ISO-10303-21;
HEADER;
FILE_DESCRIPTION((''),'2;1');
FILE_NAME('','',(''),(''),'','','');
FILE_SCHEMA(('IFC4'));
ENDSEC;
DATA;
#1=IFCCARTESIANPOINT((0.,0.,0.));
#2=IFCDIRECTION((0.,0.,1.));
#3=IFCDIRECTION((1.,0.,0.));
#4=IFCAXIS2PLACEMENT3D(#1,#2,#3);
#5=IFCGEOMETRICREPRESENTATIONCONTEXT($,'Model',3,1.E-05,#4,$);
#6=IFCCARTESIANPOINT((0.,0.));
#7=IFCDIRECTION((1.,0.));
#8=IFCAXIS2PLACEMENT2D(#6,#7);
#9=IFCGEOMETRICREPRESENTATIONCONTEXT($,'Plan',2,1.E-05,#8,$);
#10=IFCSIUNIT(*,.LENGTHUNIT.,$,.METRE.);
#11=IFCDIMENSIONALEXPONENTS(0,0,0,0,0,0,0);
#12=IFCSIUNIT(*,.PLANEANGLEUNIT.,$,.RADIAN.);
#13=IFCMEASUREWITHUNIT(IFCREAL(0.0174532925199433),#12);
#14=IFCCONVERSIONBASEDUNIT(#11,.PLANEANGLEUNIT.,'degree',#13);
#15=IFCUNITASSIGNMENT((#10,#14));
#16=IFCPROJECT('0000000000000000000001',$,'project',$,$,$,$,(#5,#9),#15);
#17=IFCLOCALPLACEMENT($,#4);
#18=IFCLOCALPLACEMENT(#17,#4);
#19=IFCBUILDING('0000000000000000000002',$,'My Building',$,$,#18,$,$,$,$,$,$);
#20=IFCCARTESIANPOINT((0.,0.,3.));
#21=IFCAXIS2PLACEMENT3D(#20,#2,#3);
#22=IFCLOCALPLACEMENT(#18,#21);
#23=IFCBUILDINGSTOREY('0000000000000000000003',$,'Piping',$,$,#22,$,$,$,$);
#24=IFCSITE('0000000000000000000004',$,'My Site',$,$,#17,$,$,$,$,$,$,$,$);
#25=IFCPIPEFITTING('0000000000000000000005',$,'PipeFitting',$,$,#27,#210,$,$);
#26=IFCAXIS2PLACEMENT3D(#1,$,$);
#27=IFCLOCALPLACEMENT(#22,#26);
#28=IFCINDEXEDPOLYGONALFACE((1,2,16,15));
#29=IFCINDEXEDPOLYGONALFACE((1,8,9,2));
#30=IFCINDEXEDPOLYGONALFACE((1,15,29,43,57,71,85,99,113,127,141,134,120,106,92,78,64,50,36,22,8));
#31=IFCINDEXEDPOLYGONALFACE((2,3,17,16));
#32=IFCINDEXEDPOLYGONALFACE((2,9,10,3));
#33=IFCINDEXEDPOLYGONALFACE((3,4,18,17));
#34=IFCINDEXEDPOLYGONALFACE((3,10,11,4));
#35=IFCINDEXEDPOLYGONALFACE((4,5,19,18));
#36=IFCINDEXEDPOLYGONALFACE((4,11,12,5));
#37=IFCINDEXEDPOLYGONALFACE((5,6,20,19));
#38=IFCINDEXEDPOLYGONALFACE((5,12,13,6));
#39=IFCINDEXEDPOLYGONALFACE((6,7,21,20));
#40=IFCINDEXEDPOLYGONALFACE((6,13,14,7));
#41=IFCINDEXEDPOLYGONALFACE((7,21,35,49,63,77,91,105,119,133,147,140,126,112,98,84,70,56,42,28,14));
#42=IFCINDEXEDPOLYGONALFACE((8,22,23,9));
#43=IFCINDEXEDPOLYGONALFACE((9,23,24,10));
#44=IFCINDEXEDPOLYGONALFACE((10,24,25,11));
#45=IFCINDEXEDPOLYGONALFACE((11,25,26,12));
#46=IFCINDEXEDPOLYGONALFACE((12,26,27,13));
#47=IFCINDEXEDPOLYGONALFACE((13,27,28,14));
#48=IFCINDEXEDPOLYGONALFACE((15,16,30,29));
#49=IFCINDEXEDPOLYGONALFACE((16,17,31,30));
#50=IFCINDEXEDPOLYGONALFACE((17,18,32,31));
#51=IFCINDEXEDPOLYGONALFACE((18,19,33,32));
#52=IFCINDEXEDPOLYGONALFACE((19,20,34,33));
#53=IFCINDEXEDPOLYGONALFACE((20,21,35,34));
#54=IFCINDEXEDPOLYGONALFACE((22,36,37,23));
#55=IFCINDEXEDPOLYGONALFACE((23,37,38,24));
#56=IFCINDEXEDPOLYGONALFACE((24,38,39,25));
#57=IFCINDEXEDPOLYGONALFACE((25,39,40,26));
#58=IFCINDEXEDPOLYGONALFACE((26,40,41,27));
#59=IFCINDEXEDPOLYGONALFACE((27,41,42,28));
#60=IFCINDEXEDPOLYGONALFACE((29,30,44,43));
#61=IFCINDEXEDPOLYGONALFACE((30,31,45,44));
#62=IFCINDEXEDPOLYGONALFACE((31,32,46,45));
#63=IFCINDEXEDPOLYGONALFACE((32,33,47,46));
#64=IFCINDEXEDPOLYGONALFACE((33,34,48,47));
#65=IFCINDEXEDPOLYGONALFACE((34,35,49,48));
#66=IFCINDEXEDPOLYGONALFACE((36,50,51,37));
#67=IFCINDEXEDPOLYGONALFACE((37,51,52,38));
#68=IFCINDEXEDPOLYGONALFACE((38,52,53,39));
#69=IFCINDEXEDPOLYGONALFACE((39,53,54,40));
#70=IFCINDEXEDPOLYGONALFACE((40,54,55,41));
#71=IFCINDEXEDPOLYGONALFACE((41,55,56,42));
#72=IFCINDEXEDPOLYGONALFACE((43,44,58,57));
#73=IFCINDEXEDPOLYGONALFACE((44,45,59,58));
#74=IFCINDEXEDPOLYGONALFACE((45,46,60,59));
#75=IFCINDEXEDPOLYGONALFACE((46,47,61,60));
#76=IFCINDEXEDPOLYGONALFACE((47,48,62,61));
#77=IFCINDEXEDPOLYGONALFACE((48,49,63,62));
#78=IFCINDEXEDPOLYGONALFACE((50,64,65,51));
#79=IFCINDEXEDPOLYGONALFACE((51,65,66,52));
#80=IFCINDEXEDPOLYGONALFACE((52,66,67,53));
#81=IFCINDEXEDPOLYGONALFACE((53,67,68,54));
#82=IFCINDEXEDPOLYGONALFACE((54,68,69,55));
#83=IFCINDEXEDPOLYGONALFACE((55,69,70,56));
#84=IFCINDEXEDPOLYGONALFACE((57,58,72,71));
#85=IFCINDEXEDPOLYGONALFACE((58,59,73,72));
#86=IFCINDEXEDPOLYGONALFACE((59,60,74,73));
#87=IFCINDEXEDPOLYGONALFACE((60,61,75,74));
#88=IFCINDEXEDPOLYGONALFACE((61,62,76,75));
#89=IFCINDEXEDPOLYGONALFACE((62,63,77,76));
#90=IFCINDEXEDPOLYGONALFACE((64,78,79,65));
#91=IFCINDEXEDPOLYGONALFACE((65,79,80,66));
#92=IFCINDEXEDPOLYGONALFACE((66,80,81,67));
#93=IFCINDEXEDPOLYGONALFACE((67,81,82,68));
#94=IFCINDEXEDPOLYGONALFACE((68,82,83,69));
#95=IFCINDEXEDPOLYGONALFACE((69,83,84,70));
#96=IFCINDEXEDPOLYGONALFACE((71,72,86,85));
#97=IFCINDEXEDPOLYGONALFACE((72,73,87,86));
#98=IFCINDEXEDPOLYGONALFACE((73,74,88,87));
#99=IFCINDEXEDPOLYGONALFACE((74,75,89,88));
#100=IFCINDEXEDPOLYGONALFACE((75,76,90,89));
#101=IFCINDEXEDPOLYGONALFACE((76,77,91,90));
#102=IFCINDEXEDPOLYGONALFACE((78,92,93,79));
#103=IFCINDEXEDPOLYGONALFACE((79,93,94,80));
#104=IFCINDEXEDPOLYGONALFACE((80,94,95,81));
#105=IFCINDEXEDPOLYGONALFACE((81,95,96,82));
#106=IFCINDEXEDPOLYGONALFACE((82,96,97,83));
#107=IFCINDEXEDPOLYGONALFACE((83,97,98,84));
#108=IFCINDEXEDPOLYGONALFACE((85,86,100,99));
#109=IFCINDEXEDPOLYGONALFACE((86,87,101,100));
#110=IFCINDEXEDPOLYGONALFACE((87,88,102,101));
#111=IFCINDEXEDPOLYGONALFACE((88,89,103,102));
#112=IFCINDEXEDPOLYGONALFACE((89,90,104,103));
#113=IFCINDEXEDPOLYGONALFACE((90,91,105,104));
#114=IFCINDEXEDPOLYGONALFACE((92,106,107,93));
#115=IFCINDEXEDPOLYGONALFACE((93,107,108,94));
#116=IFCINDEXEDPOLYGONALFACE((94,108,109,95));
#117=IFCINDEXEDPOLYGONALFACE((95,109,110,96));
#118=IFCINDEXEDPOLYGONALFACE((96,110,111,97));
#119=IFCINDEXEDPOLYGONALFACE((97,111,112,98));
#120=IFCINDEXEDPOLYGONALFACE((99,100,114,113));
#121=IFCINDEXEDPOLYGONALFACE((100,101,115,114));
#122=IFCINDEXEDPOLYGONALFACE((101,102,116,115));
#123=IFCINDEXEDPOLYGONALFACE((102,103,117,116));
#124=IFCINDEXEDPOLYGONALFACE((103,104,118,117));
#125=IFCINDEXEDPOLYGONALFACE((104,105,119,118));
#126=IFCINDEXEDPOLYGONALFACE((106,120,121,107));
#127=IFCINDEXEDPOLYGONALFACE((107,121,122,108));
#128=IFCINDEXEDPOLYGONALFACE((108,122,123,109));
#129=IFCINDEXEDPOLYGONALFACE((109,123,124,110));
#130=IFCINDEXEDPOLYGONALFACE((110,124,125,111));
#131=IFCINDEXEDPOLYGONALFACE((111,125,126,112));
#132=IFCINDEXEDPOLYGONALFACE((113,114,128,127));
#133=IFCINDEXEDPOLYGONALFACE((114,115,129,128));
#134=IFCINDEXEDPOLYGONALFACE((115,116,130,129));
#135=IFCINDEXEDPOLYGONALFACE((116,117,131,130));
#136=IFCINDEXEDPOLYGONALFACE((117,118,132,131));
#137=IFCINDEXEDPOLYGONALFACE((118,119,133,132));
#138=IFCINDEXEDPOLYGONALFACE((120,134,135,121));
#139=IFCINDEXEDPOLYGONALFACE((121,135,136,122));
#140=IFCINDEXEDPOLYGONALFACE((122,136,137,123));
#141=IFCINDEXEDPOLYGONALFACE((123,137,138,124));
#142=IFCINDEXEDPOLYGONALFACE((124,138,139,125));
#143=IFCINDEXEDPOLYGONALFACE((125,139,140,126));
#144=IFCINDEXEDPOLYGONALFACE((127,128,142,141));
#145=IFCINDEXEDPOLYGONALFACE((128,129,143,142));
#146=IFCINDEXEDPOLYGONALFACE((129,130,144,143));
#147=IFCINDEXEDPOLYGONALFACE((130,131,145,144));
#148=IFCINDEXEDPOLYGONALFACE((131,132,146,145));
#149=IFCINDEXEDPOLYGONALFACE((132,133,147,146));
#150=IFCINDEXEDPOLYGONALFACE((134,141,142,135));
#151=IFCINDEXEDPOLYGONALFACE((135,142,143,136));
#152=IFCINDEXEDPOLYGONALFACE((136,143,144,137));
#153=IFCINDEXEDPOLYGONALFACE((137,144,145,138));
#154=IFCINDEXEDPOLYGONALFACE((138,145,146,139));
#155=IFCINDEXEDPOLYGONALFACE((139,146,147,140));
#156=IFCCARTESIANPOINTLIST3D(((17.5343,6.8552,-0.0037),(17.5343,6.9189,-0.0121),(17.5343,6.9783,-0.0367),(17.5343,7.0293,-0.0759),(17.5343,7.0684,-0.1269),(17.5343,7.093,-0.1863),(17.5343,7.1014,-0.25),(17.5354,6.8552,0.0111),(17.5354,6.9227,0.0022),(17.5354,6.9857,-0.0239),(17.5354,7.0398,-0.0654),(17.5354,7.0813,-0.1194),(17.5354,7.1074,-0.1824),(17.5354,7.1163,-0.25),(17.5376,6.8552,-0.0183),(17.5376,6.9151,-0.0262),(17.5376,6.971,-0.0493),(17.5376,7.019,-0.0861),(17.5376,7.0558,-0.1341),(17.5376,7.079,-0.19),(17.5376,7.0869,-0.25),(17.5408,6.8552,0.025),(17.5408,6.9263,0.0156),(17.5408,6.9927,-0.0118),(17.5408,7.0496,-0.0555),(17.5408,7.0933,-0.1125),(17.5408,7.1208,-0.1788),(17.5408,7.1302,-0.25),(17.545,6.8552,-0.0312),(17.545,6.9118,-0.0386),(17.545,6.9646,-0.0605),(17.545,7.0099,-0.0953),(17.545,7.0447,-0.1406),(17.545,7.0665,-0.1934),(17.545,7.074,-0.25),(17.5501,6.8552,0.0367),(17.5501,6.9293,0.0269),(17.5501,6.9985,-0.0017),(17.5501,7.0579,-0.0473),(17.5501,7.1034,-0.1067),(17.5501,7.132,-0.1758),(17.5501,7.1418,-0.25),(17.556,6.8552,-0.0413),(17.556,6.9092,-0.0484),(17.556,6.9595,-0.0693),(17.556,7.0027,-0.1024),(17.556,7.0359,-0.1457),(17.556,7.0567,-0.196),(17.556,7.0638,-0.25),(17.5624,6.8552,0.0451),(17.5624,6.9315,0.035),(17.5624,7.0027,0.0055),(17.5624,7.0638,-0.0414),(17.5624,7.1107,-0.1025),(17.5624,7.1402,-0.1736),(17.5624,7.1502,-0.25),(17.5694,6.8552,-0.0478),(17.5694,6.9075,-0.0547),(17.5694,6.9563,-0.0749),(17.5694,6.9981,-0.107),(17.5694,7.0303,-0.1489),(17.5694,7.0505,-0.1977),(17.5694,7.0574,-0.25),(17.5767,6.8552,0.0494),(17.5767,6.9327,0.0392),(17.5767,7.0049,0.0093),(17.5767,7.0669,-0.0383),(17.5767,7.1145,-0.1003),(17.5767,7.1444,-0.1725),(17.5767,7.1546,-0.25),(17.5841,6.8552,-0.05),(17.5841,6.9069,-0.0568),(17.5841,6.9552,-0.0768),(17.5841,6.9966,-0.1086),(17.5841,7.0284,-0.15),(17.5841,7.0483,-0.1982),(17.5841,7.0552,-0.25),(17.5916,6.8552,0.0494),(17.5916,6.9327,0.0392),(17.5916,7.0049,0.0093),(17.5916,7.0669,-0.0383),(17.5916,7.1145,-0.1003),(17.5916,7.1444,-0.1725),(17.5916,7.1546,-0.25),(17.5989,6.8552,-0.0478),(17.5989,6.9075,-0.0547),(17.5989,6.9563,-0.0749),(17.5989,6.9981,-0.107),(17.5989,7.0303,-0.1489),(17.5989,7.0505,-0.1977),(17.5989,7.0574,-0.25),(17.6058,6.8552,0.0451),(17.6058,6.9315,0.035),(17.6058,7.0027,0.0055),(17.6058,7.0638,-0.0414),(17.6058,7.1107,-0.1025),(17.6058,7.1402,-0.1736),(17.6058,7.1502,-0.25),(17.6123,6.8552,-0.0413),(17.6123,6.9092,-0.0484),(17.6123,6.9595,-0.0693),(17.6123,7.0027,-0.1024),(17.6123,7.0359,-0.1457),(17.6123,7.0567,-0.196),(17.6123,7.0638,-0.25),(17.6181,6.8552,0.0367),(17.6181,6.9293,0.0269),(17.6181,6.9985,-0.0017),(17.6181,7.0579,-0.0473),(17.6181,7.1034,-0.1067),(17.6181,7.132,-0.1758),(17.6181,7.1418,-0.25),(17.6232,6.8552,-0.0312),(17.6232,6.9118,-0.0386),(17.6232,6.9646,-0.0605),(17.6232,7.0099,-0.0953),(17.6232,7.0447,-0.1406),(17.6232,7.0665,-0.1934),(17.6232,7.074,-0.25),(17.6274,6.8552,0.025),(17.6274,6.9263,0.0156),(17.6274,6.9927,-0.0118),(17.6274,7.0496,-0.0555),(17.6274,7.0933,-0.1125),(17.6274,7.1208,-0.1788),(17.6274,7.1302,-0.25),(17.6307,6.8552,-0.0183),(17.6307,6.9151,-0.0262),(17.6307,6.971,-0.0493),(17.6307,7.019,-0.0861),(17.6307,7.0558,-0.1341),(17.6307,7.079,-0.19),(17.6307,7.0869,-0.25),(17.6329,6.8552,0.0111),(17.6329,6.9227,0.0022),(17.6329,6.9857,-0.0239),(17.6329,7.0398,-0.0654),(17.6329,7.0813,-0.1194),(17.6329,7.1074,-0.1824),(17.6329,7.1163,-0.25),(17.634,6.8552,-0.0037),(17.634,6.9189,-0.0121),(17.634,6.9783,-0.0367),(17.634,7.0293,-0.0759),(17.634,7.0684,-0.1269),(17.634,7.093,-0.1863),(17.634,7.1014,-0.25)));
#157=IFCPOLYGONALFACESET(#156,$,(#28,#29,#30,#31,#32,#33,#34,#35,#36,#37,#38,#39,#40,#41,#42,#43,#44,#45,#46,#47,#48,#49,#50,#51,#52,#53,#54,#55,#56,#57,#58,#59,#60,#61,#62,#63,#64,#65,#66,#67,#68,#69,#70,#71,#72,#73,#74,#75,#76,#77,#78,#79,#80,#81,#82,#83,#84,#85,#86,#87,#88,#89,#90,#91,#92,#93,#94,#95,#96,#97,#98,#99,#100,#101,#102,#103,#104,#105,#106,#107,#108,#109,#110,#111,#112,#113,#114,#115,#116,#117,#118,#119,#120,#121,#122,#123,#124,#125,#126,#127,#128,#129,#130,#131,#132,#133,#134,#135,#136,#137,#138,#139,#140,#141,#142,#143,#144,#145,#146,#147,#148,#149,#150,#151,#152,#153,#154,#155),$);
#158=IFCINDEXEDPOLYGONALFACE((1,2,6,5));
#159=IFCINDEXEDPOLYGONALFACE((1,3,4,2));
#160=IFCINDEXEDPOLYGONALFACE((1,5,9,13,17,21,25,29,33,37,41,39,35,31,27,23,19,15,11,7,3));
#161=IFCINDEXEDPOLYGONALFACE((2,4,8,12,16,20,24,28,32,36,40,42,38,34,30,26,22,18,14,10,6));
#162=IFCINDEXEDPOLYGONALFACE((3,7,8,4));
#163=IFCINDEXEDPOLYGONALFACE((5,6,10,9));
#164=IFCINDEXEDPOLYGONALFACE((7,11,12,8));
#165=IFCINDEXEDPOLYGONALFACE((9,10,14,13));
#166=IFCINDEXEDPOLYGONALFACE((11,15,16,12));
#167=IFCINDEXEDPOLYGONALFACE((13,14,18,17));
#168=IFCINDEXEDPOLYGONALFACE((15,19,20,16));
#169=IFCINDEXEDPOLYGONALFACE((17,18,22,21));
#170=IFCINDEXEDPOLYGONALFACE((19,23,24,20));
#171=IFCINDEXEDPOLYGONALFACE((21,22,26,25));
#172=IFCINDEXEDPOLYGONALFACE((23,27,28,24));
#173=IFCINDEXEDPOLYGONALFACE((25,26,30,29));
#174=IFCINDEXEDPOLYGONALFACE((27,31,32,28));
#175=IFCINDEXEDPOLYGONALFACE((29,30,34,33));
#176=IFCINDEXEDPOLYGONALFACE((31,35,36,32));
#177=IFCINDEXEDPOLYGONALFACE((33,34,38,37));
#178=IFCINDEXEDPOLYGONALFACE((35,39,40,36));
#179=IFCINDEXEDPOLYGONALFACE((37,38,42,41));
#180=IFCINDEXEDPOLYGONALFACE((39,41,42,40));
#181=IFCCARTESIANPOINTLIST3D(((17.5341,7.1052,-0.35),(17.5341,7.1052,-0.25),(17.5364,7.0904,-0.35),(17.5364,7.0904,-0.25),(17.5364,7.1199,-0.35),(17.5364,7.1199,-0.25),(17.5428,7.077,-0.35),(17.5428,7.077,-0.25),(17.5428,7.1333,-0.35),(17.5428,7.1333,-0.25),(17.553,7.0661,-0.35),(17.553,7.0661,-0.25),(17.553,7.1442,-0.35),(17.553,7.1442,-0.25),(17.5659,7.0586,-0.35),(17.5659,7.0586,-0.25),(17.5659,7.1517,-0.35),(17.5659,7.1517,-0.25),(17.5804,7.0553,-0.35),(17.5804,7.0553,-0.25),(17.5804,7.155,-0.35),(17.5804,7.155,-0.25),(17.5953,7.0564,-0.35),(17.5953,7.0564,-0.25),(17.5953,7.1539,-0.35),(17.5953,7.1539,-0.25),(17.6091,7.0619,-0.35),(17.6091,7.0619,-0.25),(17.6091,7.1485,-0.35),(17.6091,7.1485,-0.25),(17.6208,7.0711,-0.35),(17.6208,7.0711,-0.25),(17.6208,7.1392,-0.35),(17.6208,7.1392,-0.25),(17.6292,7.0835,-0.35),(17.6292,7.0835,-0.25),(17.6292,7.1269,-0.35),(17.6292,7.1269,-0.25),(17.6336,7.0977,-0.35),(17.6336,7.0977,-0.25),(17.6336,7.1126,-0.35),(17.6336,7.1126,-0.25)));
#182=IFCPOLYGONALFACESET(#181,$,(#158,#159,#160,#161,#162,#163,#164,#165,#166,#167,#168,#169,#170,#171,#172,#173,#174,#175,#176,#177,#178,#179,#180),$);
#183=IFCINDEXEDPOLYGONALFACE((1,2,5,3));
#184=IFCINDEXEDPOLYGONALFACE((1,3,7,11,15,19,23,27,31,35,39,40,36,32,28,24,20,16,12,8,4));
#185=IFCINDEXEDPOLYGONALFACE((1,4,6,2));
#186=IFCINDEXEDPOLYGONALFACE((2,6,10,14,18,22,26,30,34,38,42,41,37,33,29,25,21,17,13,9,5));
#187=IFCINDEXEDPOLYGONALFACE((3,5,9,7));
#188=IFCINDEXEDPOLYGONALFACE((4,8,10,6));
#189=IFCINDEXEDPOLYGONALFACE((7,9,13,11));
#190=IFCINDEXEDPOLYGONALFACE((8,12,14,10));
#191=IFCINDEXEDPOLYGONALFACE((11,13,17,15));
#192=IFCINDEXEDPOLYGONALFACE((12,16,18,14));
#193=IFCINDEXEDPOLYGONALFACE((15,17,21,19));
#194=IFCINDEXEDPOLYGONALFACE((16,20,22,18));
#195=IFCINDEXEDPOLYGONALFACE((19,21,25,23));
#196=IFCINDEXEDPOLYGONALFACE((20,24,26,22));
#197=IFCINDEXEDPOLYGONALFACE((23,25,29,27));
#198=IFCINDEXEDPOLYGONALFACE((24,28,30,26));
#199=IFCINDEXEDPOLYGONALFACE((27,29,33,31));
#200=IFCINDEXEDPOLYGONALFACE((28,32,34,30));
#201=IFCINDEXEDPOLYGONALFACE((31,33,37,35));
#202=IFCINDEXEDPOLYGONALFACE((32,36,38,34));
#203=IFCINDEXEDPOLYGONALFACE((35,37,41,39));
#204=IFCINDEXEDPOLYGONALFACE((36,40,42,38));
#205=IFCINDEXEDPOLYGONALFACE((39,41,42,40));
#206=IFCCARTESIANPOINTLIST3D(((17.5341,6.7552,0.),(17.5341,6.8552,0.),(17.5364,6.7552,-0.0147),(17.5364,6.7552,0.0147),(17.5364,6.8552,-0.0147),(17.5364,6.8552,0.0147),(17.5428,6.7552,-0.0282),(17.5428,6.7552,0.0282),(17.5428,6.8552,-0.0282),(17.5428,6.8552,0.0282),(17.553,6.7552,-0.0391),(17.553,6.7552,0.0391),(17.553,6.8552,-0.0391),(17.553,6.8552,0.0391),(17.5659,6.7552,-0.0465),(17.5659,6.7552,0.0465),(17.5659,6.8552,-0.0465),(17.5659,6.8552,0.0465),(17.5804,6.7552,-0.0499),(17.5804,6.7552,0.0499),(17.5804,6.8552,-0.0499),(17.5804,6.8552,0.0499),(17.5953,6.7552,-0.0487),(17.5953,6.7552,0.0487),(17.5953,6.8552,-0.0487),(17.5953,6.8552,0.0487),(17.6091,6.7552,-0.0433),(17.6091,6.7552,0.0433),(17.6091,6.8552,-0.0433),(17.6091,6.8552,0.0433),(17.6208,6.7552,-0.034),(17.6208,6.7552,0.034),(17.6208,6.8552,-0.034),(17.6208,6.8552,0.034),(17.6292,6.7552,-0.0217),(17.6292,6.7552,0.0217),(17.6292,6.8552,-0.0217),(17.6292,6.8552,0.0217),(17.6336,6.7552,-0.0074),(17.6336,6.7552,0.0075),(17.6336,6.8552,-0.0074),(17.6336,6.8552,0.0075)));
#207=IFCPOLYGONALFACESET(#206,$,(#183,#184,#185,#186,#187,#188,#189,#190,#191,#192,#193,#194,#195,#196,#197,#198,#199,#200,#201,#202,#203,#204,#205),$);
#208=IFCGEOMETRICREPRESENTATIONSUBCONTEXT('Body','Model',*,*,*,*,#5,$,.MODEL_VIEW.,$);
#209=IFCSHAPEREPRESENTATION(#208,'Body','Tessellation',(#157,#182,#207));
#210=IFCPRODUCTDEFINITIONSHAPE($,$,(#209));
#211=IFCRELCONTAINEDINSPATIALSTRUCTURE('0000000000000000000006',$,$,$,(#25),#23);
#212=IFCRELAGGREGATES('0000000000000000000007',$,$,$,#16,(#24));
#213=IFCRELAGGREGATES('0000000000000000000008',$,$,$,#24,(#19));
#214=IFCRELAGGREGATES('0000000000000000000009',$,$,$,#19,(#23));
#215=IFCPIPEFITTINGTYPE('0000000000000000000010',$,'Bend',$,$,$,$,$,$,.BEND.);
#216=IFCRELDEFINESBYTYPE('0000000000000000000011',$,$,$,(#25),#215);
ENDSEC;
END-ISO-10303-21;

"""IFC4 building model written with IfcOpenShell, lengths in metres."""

from ifc_helpers import new_model, entity, si_unit, converted_unit, frame, origin_with_axes, origin_2d_with_axis, place, context, subcontext, project, spatial, circle, extrude, source, transform, mapped, type_object, type_shapes, element, save


model = new_model("IFC4")

# Units and contexts
model_context = context("Model", 3, precision=1e-05, world=origin_with_axes())
plan_context = context("Plan", 2, precision=1e-05, world=origin_2d_with_axis())
body_context = subcontext(model_context, "Body", "Model", "MODEL_VIEW")
ifc_project = project(units=[si_unit("LENGTHUNIT", "METRE"), converted_unit("PLANEANGLEUNIT", "degree", entity("IfcReal", 0.0174532925199433), si_unit("PLANEANGLEUNIT", "RADIAN"), dimensions=[0, 0, 0, 0, 0, 0, 0])], contexts=[model_context, plan_context])

# Site, building, storey
site_placement = place(None, origin_with_axes())
site = spatial("IfcSite", under=ifc_project, at=site_placement, Name="My Site")
building_placement = place(site_placement, origin_with_axes())
building = spatial("IfcBuilding", under=site, at=building_placement, Name="My Building")
storey_placement = place(building_placement, frame((0.0, 0.0, 3.0), z_axis=(0.0, 0.0, 1.0), x_axis=(1.0, 0.0, 0.0)))
storey = spatial("IfcBuildingStorey", under=building, at=storey_placement, Name="Piping")

# Shared definitions
pipe_fitting_type = type_object("IfcPipeFittingType", Name="Bend", PredefinedType="BEND")
shared_shape = source(origin_with_axes(), body_context, "Body", "SolidModel", [
    entity("IfcSweptDiskSolid", entity("IfcIndexedPolyCurve", entity("IfcCartesianPointList3D", [[0.0, 0.0, -0.1], [0.0, -0.0732, -0.2768], [0.0, -0.25, -0.35]]), [entity("IfcArcIndex", [1, 2, 3])]), 0.05),
    extrude(circle(Radius=0.05), origin_with_axes(), (0.0, 0.0, -1.0), 0.1),
    extrude(circle(Radius=0.05), frame((0.0, -0.25, -0.35), z_axis=(0.0, -1.0, 0.0), x_axis=(1.0, 0.0, 0.0)), (0.0, 0.0, 1.0), 0.1),
])
type_shapes(pipe_fitting_type, [shared_shape])

# Pipe fitting
for number, where, z_axis, x_axis, name in (
    (1, (17.5841, 7.1052, -0.35), (0.0, 0.0, -1.0), (-1.0, 0.0, 0.0), "PipeFitting"),
):
    element("IfcPipeFitting", number, at=place(storey_placement, frame(where, z_axis=z_axis, x_axis=x_axis)), inside=storey, type_object=pipe_fitting_type, Name=name, context=body_context, shape_type="MappedRepresentation", body=[
        mapped(shared_shape, transform((0.0, 0.0, 0.0), x_axis=(1.0, 0.0, 0.0), y_axis=(0.0, 1.0, 0.0), z_axis=(0.0, 0.0, 1.0), scale=1.0)),
    ])

save(model, "model.ifc")
